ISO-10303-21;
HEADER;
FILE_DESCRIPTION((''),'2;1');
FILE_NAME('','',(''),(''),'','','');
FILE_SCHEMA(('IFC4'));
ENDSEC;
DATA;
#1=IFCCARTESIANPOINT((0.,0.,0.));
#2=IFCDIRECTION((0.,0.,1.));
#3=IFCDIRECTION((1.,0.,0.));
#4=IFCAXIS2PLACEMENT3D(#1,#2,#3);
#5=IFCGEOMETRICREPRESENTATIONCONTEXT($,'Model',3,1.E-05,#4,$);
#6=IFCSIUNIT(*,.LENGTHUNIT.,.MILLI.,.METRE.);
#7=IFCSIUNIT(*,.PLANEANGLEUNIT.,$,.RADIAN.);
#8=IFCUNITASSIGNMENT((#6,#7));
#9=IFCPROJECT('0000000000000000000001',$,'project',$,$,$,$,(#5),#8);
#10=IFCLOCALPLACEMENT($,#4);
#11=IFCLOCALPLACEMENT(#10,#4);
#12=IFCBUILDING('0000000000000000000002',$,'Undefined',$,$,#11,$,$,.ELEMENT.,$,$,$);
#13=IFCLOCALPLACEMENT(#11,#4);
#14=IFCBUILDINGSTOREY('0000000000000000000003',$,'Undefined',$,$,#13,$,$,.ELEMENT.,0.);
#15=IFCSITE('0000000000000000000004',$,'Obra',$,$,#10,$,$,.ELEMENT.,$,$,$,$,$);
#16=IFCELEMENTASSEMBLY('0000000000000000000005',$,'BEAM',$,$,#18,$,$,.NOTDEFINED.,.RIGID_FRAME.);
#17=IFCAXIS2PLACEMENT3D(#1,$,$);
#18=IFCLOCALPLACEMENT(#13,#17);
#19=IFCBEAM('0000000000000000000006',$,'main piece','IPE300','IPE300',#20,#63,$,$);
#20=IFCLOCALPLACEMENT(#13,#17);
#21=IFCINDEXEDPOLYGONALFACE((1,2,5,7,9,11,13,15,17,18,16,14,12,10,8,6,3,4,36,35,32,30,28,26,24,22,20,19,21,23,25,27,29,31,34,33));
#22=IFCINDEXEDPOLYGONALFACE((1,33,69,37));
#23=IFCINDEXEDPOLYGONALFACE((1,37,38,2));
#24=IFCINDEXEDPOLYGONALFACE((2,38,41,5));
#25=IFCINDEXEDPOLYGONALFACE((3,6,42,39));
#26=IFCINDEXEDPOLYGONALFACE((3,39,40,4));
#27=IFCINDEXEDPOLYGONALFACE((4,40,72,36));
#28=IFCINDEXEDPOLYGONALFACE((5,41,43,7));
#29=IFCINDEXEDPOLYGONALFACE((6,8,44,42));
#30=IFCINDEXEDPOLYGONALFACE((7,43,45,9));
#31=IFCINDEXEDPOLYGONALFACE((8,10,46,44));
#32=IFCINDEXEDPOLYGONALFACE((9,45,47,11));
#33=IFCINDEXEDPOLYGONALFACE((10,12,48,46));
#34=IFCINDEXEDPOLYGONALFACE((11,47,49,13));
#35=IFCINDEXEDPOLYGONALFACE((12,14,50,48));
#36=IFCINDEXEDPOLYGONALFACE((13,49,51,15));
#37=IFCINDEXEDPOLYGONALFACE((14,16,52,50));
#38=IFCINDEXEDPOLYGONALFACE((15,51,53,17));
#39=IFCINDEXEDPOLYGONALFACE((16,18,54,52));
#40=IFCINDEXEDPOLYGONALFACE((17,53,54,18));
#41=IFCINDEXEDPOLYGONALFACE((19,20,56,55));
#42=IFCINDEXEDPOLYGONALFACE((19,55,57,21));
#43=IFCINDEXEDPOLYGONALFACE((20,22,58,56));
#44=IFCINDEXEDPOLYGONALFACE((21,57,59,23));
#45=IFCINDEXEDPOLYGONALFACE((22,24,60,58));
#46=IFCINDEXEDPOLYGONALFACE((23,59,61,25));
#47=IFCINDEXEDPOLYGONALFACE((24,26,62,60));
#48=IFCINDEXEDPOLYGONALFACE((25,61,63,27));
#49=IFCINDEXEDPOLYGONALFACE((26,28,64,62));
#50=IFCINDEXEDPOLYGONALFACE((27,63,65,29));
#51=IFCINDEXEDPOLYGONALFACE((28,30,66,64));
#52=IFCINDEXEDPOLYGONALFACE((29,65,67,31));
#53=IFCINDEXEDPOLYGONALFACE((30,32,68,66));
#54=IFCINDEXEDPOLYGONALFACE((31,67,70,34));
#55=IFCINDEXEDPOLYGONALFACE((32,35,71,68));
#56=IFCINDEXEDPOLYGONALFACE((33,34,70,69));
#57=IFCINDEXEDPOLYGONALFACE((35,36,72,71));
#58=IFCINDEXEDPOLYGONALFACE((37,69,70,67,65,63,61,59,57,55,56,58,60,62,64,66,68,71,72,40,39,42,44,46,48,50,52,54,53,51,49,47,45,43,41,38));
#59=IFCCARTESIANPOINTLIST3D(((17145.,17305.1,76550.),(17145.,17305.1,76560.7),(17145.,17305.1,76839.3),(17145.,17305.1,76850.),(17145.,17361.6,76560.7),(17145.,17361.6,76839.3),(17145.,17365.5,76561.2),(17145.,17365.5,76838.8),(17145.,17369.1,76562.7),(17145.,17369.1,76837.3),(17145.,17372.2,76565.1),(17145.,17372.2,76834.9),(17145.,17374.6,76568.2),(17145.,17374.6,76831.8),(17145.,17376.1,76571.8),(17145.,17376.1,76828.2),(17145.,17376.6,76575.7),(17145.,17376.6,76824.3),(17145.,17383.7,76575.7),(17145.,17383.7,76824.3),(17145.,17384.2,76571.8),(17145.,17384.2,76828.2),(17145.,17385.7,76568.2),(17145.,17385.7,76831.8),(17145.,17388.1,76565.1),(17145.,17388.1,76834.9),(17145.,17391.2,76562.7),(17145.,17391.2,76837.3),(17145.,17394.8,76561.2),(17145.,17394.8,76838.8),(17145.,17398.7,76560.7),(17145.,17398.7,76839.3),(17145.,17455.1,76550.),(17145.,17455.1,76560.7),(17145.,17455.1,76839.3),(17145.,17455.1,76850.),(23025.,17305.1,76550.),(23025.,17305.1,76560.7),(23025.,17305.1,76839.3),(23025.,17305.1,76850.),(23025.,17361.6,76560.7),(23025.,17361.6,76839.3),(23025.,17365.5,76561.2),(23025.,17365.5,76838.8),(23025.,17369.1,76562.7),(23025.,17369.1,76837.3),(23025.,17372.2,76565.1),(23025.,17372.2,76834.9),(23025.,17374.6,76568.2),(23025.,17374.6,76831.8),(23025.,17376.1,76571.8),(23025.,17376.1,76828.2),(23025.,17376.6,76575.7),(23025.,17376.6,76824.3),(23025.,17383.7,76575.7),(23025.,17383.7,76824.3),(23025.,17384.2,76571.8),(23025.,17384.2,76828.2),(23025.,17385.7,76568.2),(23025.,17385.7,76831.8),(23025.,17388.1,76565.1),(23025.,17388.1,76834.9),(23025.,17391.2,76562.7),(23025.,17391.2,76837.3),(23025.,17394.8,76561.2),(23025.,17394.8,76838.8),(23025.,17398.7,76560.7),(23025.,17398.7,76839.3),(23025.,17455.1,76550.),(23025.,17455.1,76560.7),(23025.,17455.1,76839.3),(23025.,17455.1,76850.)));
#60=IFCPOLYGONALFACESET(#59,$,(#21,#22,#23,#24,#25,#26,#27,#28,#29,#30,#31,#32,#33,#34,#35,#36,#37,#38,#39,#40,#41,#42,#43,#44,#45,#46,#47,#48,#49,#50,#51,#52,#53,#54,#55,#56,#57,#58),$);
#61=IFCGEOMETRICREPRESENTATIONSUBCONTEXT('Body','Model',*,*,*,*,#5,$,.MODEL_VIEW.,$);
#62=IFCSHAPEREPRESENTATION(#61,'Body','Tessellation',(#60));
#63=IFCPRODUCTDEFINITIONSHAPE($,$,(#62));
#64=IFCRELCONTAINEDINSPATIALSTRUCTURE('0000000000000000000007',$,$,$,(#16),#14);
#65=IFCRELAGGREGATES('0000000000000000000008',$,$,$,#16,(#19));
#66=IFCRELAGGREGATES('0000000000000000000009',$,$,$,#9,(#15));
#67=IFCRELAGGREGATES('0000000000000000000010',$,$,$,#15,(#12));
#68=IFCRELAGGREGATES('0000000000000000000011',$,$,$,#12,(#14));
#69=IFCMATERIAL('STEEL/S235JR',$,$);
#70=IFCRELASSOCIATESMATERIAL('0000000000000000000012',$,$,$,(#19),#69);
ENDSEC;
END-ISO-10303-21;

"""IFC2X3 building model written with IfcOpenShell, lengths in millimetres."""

from ifc_helpers import new_model, si_unit, frame, origin_with_axes, origin_2d_with_axis, place, context, subcontext, project, spatial, i_section, extrude, material, element, aggregate, save


model = new_model("IFC2X3")

# Units and contexts
model_context = context("Model", 3, precision=1e-05, world=origin_with_axes())
body_context = subcontext(model_context, "Body", "Model", "MODEL_VIEW")
ifc_project = project(units=[si_unit("LENGTHUNIT", "METRE", prefix="MILLI"), si_unit("PLANEANGLEUNIT", "RADIAN")], contexts=[model_context])

# Site, building, storey
site_placement = place(None, origin_with_axes())
site = spatial("IfcSite", under=ifc_project, at=site_placement, Name="Obra", CompositionType="ELEMENT")
building_placement = place(site_placement, origin_with_axes())
building = spatial("IfcBuilding", under=site, at=building_placement, Name="Undefined", CompositionType="ELEMENT")
storey_placement = place(building_placement, origin_with_axes())
storey = spatial("IfcBuildingStorey", under=building, at=storey_placement, Name="Undefined", CompositionType="ELEMENT", Elevation=0.0)

# Element assembly, beam
assembly_1_placement = place(storey_placement, origin_with_axes())
assembly_1 = element("IfcElementAssembly", 1, at=assembly_1_placement, inside=storey, Name="BEAM", AssemblyPlace="NOTDEFINED", PredefinedType="RIGID_FRAME")
ifc_material = material(Name="STEEL/S235JR")
beam_1_placement = place(assembly_1_placement, frame((17145.0, 17380.1, 76700.0), z_axis=(0.0, 0.0, 1.0), x_axis=(1.0, 0.0, 0.0)))
beam_1 = element("IfcBeam", 2, at=beam_1_placement, material=ifc_material, Name="main piece", Description="IPE300", ObjectType="IPE300", context=body_context, shape_type="SweptSolid", body=[
    extrude(i_section(OverallWidth=150.0, OverallDepth=300.0, WebThickness=7.1, FlangeThickness=10.7, FilletRadius=15.0, at=origin_2d_with_axis()), frame((5880.0, 0.0, 0.0), z_axis=(-1.0, 0.0, 0.0), x_axis=(0.0, -1.0, 0.0)), (0.0, 0.0, 1.0), 5880.0),
])
aggregate(assembly_1, [beam_1])

save(model, "model.ifc")
